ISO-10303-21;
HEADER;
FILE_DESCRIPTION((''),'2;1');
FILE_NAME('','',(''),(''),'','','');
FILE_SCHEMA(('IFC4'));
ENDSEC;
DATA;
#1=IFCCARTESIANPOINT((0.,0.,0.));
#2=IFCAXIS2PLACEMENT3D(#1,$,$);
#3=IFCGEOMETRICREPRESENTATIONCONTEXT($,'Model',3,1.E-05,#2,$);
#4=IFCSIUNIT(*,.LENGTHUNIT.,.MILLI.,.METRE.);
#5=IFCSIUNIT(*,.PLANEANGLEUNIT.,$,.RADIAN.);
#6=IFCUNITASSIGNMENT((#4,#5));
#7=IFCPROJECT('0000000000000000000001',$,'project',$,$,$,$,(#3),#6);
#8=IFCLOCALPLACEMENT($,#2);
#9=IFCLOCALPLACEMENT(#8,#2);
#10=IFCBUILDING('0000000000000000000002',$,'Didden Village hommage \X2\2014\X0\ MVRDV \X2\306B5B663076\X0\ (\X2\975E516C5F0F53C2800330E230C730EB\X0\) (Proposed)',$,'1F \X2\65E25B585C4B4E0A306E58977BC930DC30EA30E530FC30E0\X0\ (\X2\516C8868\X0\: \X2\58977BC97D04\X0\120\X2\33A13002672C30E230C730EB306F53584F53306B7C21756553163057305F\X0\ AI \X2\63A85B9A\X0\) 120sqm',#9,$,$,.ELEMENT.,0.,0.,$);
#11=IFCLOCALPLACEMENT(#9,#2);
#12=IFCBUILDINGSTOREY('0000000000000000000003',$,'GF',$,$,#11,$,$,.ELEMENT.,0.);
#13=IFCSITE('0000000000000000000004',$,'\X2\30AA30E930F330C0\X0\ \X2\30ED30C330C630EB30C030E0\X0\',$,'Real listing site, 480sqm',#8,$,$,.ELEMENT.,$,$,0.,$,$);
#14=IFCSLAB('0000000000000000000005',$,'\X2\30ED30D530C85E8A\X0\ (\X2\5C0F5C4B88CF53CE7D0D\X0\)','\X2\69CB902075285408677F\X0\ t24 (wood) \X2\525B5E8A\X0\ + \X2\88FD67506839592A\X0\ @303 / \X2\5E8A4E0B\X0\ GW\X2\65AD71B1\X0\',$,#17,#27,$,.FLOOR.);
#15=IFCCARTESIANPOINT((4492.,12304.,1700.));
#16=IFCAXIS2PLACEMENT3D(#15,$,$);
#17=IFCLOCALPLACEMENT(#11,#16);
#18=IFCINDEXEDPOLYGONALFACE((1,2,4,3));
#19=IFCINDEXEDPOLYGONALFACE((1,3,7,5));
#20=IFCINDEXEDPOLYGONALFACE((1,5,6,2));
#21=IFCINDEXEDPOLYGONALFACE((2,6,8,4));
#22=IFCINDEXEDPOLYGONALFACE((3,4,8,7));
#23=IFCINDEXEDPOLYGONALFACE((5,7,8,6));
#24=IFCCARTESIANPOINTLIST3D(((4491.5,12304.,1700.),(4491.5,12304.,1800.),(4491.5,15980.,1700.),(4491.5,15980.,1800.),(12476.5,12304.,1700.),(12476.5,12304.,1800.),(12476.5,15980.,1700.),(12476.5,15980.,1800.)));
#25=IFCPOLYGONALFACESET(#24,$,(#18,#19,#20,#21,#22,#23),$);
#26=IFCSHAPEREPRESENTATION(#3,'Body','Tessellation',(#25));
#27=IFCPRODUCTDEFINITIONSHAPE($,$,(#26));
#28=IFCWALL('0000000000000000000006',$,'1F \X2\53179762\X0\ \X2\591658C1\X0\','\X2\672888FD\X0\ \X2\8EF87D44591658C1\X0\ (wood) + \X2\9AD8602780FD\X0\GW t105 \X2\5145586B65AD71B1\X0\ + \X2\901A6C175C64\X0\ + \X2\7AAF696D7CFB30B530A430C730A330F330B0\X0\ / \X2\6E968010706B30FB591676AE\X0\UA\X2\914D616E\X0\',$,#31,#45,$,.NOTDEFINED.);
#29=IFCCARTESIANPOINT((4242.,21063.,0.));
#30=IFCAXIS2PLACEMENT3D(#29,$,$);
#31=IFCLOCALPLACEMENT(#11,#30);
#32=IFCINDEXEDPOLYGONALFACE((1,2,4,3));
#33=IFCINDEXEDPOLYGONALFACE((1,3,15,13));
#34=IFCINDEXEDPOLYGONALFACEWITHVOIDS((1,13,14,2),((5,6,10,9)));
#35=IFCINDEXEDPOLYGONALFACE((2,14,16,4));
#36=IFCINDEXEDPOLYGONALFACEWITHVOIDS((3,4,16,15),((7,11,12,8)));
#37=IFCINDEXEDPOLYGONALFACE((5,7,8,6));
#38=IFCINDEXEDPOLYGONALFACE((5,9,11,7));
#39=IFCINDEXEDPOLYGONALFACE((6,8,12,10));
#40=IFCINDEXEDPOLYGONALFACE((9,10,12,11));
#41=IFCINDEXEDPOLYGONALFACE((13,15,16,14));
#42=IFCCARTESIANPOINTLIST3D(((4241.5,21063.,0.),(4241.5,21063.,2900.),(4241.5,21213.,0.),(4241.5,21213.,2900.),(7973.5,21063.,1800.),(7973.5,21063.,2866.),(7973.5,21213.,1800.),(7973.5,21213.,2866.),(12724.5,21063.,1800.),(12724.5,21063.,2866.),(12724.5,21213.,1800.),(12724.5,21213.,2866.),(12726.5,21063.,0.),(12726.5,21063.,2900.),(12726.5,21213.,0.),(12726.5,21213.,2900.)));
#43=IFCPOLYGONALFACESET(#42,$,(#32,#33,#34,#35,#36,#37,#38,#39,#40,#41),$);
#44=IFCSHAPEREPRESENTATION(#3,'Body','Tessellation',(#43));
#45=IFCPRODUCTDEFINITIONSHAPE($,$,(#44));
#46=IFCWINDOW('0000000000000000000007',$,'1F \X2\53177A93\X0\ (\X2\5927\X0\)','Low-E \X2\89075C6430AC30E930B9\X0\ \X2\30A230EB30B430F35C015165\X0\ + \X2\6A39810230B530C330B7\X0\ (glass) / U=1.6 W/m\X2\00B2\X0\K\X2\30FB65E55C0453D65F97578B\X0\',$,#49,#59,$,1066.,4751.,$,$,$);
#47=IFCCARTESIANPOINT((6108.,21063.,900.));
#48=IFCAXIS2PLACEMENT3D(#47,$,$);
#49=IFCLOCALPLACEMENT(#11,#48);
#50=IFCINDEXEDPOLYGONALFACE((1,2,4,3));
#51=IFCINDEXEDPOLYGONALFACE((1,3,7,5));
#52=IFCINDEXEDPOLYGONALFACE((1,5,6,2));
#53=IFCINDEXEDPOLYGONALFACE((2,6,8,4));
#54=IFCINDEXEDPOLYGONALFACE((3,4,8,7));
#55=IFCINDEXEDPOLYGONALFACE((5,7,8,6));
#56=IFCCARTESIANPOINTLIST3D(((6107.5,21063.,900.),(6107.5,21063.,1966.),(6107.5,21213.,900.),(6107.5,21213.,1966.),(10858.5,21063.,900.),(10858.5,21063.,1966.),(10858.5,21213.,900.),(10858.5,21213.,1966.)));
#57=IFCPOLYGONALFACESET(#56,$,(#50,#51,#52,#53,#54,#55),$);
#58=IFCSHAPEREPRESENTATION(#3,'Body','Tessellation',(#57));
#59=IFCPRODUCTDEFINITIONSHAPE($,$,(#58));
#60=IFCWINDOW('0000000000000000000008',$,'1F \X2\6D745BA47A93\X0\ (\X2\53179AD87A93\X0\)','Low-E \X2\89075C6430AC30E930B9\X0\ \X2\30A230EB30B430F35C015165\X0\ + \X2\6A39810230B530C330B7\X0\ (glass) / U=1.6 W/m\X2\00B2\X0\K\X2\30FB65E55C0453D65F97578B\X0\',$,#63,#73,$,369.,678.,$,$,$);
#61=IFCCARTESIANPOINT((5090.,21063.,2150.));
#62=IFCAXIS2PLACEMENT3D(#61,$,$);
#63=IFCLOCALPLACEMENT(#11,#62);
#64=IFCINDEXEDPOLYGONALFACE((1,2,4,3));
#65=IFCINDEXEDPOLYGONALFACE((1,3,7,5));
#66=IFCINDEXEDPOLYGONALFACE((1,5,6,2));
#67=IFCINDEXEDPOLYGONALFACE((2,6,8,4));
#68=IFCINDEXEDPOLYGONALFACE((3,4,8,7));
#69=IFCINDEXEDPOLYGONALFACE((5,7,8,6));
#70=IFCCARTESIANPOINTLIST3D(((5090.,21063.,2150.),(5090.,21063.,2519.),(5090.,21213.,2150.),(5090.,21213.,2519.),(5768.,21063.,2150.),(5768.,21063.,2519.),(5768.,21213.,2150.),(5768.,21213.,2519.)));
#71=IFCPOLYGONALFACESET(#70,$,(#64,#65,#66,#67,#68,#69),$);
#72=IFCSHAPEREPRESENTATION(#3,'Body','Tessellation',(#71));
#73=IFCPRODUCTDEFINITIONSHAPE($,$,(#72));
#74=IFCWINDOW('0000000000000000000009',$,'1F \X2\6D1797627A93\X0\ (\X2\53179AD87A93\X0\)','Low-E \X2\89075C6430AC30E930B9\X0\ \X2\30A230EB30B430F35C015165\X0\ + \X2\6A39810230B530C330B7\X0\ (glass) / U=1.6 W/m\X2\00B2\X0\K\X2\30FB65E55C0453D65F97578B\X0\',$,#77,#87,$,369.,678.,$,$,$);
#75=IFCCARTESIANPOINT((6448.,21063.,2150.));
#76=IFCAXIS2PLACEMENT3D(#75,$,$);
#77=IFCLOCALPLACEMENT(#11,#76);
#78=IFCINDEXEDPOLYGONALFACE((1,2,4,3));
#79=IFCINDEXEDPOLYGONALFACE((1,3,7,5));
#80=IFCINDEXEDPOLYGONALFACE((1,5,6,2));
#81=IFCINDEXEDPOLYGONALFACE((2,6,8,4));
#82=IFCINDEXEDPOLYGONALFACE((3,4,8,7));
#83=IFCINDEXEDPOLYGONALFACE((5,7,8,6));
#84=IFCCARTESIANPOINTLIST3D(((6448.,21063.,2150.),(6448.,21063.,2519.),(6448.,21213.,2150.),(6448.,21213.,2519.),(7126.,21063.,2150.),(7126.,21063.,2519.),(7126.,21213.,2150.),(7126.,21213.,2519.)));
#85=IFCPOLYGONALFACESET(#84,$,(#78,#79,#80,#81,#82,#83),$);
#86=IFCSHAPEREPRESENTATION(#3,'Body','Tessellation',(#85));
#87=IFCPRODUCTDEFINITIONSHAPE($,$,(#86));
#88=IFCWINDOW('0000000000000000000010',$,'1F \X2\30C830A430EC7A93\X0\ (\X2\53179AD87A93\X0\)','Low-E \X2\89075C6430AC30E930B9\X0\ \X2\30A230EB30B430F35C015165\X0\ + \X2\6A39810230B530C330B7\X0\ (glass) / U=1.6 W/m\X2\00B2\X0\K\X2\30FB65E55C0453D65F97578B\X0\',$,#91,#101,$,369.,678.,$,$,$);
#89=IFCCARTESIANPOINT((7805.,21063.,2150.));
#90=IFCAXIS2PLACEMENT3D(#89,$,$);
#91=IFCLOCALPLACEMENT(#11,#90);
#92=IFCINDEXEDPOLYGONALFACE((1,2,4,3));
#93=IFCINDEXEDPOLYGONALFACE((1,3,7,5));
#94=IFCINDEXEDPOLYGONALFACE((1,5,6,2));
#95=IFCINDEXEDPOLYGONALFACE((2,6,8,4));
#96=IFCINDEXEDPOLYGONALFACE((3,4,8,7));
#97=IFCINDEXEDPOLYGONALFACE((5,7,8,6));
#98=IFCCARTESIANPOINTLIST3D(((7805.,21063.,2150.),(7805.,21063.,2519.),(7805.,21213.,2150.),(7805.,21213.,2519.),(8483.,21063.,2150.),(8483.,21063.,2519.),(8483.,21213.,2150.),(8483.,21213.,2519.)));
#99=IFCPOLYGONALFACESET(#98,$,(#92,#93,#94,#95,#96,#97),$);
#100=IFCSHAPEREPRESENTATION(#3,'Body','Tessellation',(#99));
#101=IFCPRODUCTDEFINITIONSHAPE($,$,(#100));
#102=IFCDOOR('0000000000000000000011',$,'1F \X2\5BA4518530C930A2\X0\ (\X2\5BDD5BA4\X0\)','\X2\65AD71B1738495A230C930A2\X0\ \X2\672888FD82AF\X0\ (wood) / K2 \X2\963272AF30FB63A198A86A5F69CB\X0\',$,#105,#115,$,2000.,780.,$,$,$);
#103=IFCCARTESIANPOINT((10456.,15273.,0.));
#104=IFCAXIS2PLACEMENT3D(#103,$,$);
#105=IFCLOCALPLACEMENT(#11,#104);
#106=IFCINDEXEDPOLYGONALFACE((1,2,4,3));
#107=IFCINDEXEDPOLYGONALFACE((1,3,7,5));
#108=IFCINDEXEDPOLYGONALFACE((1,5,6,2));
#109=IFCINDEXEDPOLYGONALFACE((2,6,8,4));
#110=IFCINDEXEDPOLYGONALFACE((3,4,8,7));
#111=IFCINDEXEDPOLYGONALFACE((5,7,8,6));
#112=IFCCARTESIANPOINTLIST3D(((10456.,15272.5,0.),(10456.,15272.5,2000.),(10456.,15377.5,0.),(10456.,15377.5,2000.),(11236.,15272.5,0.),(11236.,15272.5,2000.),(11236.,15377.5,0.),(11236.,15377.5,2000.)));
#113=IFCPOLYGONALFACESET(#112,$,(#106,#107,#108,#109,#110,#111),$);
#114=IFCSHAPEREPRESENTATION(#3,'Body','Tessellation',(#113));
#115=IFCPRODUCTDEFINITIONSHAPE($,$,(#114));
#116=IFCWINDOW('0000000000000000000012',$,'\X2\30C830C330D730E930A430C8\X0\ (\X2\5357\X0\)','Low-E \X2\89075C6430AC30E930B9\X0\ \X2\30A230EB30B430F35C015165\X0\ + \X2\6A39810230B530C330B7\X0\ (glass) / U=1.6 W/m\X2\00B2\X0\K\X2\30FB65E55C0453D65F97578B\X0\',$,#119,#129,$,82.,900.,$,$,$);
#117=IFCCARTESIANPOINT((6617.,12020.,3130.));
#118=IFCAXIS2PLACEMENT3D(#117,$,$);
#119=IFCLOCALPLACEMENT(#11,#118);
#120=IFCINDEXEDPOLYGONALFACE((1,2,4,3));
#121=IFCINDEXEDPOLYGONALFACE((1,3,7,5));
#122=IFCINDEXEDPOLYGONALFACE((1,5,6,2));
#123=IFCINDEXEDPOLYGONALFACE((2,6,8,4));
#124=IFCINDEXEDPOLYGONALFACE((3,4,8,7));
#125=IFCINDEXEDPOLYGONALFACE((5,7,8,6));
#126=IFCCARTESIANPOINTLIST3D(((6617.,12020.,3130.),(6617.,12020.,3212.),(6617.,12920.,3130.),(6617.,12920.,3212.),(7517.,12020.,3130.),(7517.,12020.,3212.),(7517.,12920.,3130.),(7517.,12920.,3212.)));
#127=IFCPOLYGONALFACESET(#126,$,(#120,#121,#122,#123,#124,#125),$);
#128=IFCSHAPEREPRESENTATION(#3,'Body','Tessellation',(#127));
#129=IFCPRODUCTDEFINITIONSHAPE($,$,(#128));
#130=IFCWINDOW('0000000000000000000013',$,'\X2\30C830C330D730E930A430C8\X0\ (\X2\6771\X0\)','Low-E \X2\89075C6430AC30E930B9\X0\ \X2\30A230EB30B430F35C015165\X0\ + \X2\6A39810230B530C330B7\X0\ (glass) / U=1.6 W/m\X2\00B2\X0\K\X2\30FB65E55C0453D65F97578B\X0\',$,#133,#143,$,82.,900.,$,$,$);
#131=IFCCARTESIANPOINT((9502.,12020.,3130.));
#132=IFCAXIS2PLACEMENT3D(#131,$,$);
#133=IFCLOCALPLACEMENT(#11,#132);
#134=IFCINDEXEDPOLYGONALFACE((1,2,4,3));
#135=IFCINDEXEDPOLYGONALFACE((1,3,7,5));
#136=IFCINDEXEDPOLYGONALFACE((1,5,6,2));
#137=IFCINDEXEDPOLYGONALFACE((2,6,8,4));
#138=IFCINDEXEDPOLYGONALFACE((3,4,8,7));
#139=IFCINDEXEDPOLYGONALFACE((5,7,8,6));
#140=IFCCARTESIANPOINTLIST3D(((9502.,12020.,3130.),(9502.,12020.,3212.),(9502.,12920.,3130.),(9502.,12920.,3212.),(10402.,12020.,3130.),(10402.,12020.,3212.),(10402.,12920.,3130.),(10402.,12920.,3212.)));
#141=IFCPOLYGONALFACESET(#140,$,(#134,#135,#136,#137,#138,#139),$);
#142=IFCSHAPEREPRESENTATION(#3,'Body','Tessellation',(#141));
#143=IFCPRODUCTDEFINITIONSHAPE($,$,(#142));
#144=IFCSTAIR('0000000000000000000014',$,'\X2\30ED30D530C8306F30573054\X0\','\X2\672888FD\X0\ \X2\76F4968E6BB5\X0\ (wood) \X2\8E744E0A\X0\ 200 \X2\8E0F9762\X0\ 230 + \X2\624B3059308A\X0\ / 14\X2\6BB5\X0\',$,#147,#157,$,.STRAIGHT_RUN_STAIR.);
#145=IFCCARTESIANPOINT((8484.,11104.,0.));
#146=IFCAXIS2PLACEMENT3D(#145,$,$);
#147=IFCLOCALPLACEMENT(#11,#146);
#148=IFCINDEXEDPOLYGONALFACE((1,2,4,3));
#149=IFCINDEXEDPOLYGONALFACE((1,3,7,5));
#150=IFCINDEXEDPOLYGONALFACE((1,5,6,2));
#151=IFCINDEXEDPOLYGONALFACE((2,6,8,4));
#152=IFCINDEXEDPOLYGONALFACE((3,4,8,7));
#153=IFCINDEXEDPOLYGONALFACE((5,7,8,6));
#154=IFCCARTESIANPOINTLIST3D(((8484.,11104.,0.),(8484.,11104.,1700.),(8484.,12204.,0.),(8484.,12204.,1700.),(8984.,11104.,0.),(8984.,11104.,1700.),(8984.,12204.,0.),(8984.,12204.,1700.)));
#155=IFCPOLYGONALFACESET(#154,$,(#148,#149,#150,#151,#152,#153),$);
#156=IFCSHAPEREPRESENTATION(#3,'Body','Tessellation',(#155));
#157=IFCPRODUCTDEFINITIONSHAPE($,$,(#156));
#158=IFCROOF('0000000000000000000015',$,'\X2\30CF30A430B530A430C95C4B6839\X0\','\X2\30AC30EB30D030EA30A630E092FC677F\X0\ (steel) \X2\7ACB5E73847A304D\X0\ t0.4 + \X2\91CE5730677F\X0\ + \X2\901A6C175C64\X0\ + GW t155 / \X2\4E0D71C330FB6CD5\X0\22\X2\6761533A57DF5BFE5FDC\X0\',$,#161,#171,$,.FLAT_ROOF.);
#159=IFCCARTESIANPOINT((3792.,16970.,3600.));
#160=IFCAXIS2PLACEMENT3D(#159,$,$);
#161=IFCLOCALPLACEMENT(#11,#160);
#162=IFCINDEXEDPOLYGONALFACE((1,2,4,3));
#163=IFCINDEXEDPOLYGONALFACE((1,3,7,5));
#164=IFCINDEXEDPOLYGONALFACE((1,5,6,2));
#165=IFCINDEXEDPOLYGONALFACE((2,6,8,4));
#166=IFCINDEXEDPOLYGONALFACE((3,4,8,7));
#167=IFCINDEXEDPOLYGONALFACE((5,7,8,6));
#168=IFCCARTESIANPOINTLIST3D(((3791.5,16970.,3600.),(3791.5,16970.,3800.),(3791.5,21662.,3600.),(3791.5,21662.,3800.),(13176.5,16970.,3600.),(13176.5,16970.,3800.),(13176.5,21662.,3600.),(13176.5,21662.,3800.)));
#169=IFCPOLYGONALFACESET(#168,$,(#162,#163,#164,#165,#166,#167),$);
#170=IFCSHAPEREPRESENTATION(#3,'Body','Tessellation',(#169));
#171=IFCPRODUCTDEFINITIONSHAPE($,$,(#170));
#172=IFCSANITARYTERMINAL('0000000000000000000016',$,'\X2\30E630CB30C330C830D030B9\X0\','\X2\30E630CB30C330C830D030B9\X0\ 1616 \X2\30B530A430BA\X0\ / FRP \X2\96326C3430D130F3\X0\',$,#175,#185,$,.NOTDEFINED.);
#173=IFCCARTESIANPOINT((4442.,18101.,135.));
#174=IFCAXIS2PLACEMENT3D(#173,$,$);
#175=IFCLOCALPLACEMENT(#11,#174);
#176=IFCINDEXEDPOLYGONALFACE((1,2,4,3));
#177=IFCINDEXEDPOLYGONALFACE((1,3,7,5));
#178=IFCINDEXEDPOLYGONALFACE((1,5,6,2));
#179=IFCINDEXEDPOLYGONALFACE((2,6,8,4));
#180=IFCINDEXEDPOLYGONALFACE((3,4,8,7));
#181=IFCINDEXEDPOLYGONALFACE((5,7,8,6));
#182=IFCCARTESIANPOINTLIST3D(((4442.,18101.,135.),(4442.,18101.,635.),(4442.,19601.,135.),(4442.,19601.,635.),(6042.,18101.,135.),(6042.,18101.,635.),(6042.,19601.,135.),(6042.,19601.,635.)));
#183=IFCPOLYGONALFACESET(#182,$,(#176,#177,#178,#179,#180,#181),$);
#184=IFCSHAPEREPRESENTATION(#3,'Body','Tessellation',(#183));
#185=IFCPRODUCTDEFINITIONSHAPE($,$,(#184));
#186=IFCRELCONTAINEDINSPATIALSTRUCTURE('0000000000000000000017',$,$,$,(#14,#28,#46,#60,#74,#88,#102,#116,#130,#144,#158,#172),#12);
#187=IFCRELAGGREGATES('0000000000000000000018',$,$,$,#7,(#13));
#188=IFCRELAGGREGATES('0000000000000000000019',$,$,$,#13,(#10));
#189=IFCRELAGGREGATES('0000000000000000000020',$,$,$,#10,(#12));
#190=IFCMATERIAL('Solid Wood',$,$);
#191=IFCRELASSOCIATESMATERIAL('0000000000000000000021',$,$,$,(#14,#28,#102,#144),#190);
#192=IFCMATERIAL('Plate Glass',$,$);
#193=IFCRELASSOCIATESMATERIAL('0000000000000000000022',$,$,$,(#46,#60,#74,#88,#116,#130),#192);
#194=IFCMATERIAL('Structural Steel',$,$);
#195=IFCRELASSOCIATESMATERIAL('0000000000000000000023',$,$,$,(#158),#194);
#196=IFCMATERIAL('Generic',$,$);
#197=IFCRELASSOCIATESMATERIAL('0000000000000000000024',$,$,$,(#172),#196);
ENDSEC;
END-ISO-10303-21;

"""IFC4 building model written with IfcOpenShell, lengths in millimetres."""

from ifc_helpers import new_model, si_unit, frame, frame_2d, origin, place, context, project, spatial, rectangle, extrude, material, element, fill, save


model = new_model("IFC4")

# Units and contexts
model_context = context("Model", 3, precision=1e-05, world=origin())
ifc_project = project(units=[si_unit("LENGTHUNIT", "METRE", prefix="MILLI"), si_unit("PLANEANGLEUNIT", "RADIAN")], contexts=[model_context])

# Site, building, storey
site_placement = place(None, origin())
site = spatial("IfcSite", under=ifc_project, at=site_placement, Name="オランダ ロッテルダム", ObjectType="Real listing site, 480sqm", CompositionType="ELEMENT", RefElevation=0.0)
building_placement = place(site_placement, origin())
building = spatial("IfcBuilding", under=site, at=building_placement, Name="Didden Village hommage — MVRDV に学ぶ (非公式参考モデル) (Proposed)", ObjectType="1F 既存屋上の増築ボリューム (公表: 増築約120㎡。本モデルは単体に簡略化した AI 推定) 120sqm", CompositionType="ELEMENT", ElevationOfRefHeight=0.0, ElevationOfTerrain=0.0)
storey_placement = place(building_placement, origin())
storey = spatial("IfcBuildingStorey", under=building, at=storey_placement, Name="GF", CompositionType="ELEMENT", Elevation=0.0)

# Slab
ifc_material_1 = material(Name="Solid Wood")
slab_placement = place(storey_placement, frame((4492.0, 12304.0, 1700.0)))
element("IfcSlab", 1, at=slab_placement, inside=storey, material=ifc_material_1, Name="ロフト床 (小屋裏収納)", Description="構造用合板 t24 (wood) 剛床 + 製材根太 @303 / 床下 GW断熱", PredefinedType="FLOOR", context=model_context, shape_type="SweptSolid", body=[
    extrude(rectangle(XDim=7985.0, YDim=3676.0, at=frame_2d((3992.0, 1838.0))), frame((4492.0, 12304.0, 1700.0)), (0.0, 0.0, 1.0), 100.0),
])

# Wall, openings, windows
wall_1_placement = place(storey_placement, frame((4242.0, 21063.0, 0.0)))
wall_1 = element("IfcWall", 2, at=wall_1_placement, inside=storey, material=ifc_material_1, Name="1F 北面 外壁", Description="木製 軸組外壁 (wood) + 高性能GW t105 充填断熱 + 通気層 + 窯業系サイディング / 準耐火・外皮UA配慮", PredefinedType="NOTDEFINED", context=model_context, shape_type="SweptSolid", body=[
    extrude(rectangle(XDim=8485.0, YDim=150.0, at=frame_2d((4242.0, 75.0))), frame((4242.0, 21063.0, 0.0)), (0.0, 0.0, 1.0), 2900.0),
])
opening_1_placement = place(storey_placement, frame((6108.0, 21063.0, 900.0)))
opening_1 = element("IfcOpeningElement", 3, at=opening_1_placement, cuts=wall_1, PredefinedType="NOTDEFINED", context=model_context, shape_type="SweptSolid", body=[
    extrude(rectangle(XDim=4751.0, YDim=150.0, at=frame_2d((2375.0, 75.0))), frame((6108.0, 21063.0, 900.0)), (0.0, 0.0, 1.0), 1066.0),
])
opening_2_placement = place(storey_placement, frame((5090.0, 21063.0, 2150.0)))
opening_2 = element("IfcOpeningElement", 4, at=opening_2_placement, cuts=wall_1, PredefinedType="NOTDEFINED", context=model_context, shape_type="SweptSolid", body=[
    extrude(rectangle(XDim=678.0, YDim=150.0, at=frame_2d((339.0, 75.0))), frame((5090.0, 21063.0, 2150.0)), (0.0, 0.0, 1.0), 369.0),
])
opening_3_placement = place(storey_placement, frame((6448.0, 21063.0, 2150.0)))
opening_3 = element("IfcOpeningElement", 5, at=opening_3_placement, cuts=wall_1, PredefinedType="NOTDEFINED", context=model_context, shape_type="SweptSolid", body=[
    extrude(rectangle(XDim=678.0, YDim=150.0, at=frame_2d((339.0, 75.0))), frame((6448.0, 21063.0, 2150.0)), (0.0, 0.0, 1.0), 369.0),
])
opening_4_placement = place(storey_placement, frame((7805.0, 21063.0, 2150.0)))
opening_4 = element("IfcOpeningElement", 6, at=opening_4_placement, cuts=wall_1, PredefinedType="NOTDEFINED", context=model_context, shape_type="SweptSolid", body=[
    extrude(rectangle(XDim=678.0, YDim=150.0, at=frame_2d((339.0, 75.0))), frame((7805.0, 21063.0, 2150.0)), (0.0, 0.0, 1.0), 369.0),
])
ifc_material_2 = material(Name="Plate Glass")
window_1_placement = place(storey_placement, frame((6108.0, 21063.0, 900.0)))
window_1 = element("IfcWindow", 7, at=window_1_placement, inside=storey, material=ifc_material_2, Name="1F 北窓 (大)", Description="Low-E 複層ガラス アルゴン封入 + 樹脂サッシ (glass) / U=1.6 W/m²K・日射取得型", OverallHeight=1066.0, OverallWidth=4751.0, context=model_context, shape_type="SweptSolid", body=[
    extrude(rectangle(XDim=4751.0, YDim=150.0, at=frame_2d((2375.0, 75.0))), frame((6108.0, 21063.0, 900.0)), (0.0, 0.0, 1.0), 1066.0),
])
fill(opening_1, window_1)
window_2_placement = place(storey_placement, frame((5090.0, 21063.0, 2150.0)))
window_2 = element("IfcWindow", 8, at=window_2_placement, inside=storey, material=ifc_material_2, Name="1F 浴室窓 (北高窓)", Description="Low-E 複層ガラス アルゴン封入 + 樹脂サッシ (glass) / U=1.6 W/m²K・日射取得型", OverallHeight=369.0, OverallWidth=678.0, context=model_context, shape_type="SweptSolid", body=[
    extrude(rectangle(XDim=678.0, YDim=150.0, at=frame_2d((339.0, 75.0))), frame((5090.0, 21063.0, 2150.0)), (0.0, 0.0, 1.0), 369.0),
])
fill(opening_2, window_2)
window_3_placement = place(storey_placement, frame((6448.0, 21063.0, 2150.0)))
window_3 = element("IfcWindow", 9, at=window_3_placement, inside=storey, material=ifc_material_2, Name="1F 洗面窓 (北高窓)", Description="Low-E 複層ガラス アルゴン封入 + 樹脂サッシ (glass) / U=1.6 W/m²K・日射取得型", OverallHeight=369.0, OverallWidth=678.0, context=model_context, shape_type="SweptSolid", body=[
    extrude(rectangle(XDim=678.0, YDim=150.0, at=frame_2d((339.0, 75.0))), frame((6448.0, 21063.0, 2150.0)), (0.0, 0.0, 1.0), 369.0),
])
fill(opening_3, window_3)
window_4_placement = place(storey_placement, frame((7805.0, 21063.0, 2150.0)))
window_4 = element("IfcWindow", 10, at=window_4_placement, inside=storey, material=ifc_material_2, Name="1F トイレ窓 (北高窓)", Description="Low-E 複層ガラス アルゴン封入 + 樹脂サッシ (glass) / U=1.6 W/m²K・日射取得型", OverallHeight=369.0, OverallWidth=678.0, context=model_context, shape_type="SweptSolid", body=[
    extrude(rectangle(XDim=678.0, YDim=150.0, at=frame_2d((339.0, 75.0))), frame((7805.0, 21063.0, 2150.0)), (0.0, 0.0, 1.0), 369.0),
])
fill(opening_4, window_4)

# Door
door_1_placement = place(storey_placement, frame((10456.0, 15273.0, 0.0)))
element("IfcDoor", 11, at=door_1_placement, inside=storey, material=ifc_material_1, Name="1F 室内ドア (寝室)", Description="断熱玄関ドア 木製芯 (wood) / K2 防犯・採風機構", OverallHeight=2000.0, OverallWidth=780.0, context=model_context, shape_type="SweptSolid", body=[
    extrude(rectangle(XDim=780.0, YDim=105.0, at=frame_2d((390.0, 52.0))), frame((10456.0, 15273.0, 0.0)), (0.0, 0.0, 1.0), 2000.0),
])

# Windows
window_5_placement = place(storey_placement, frame((6617.0, 12020.0, 3130.0)))
element("IfcWindow", 12, at=window_5_placement, inside=storey, material=ifc_material_2, Name="トップライト (南)", Description="Low-E 複層ガラス アルゴン封入 + 樹脂サッシ (glass) / U=1.6 W/m²K・日射取得型", OverallHeight=82.0, OverallWidth=900.0, context=model_context, shape_type="SweptSolid", body=[
    extrude(rectangle(XDim=900.0, YDim=900.0, at=frame_2d((450.0, 450.0))), frame((6617.0, 12020.0, 3130.0)), (0.0, 0.0, 1.0), 82.0),
])
window_6_placement = place(storey_placement, frame((9502.0, 12020.0, 3130.0)))
element("IfcWindow", 13, at=window_6_placement, inside=storey, material=ifc_material_2, Name="トップライト (東)", Description="Low-E 複層ガラス アルゴン封入 + 樹脂サッシ (glass) / U=1.6 W/m²K・日射取得型", OverallHeight=82.0, OverallWidth=900.0, context=model_context, shape_type="SweptSolid", body=[
    extrude(rectangle(XDim=900.0, YDim=900.0, at=frame_2d((450.0, 450.0))), frame((9502.0, 12020.0, 3130.0)), (0.0, 0.0, 1.0), 82.0),
])

# Stair
stair_placement = place(storey_placement, frame((8484.0, 11104.0, 0.0)))
element("IfcStair", 14, at=stair_placement, inside=storey, material=ifc_material_1, Name="ロフトはしご", Description="木製 直階段 (wood) 蹴上 200 踏面 230 + 手すり / 14段", PredefinedType="STRAIGHT_RUN_STAIR", context=model_context, shape_type="SweptSolid", body=[
    extrude(rectangle(XDim=500.0, YDim=1100.0, at=frame_2d((250.0, 550.0))), frame((8484.0, 11104.0, 0.0)), (0.0, 0.0, 1.0), 1700.0),
])

# Roof
ifc_material_3 = material(Name="Structural Steel")
roof_placement = place(storey_placement, frame((3792.0, 16970.0, 3600.0)))
element("IfcRoof", 15, at=roof_placement, inside=storey, material=ifc_material_3, Name="ハイサイド屋根", Description="ガルバリウム鋼板 (steel) 立平葺き t0.4 + 野地板 + 通気層 + GW t155 / 不燃・法22条区域対応", PredefinedType="FLAT_ROOF", context=model_context, shape_type="SweptSolid", body=[
    extrude(rectangle(XDim=9385.0, YDim=4692.0, at=frame_2d((4692.0, 2346.0))), frame((3792.0, 16970.0, 3600.0)), (0.0, 0.0, 1.0), 200.0),
])

# Sanitary terminal
ifc_material_4 = material(Name="Generic")
sanitary_terminal_1_placement = place(storey_placement, frame((4442.0, 18101.0, 135.0)))
element("IfcSanitaryTerminal", 16, at=sanitary_terminal_1_placement, inside=storey, material=ifc_material_4, Name="ユニットバス", Description="ユニットバス 1616 サイズ / FRP 防水パン", PredefinedType="NOTDEFINED", context=model_context, shape_type="SweptSolid", body=[
    extrude(rectangle(XDim=1600.0, YDim=1500.0, at=frame_2d((800.0, 750.0))), frame((4442.0, 18101.0, 135.0)), (0.0, 0.0, 1.0), 500.0),
])

save(model, "model.ifc")
